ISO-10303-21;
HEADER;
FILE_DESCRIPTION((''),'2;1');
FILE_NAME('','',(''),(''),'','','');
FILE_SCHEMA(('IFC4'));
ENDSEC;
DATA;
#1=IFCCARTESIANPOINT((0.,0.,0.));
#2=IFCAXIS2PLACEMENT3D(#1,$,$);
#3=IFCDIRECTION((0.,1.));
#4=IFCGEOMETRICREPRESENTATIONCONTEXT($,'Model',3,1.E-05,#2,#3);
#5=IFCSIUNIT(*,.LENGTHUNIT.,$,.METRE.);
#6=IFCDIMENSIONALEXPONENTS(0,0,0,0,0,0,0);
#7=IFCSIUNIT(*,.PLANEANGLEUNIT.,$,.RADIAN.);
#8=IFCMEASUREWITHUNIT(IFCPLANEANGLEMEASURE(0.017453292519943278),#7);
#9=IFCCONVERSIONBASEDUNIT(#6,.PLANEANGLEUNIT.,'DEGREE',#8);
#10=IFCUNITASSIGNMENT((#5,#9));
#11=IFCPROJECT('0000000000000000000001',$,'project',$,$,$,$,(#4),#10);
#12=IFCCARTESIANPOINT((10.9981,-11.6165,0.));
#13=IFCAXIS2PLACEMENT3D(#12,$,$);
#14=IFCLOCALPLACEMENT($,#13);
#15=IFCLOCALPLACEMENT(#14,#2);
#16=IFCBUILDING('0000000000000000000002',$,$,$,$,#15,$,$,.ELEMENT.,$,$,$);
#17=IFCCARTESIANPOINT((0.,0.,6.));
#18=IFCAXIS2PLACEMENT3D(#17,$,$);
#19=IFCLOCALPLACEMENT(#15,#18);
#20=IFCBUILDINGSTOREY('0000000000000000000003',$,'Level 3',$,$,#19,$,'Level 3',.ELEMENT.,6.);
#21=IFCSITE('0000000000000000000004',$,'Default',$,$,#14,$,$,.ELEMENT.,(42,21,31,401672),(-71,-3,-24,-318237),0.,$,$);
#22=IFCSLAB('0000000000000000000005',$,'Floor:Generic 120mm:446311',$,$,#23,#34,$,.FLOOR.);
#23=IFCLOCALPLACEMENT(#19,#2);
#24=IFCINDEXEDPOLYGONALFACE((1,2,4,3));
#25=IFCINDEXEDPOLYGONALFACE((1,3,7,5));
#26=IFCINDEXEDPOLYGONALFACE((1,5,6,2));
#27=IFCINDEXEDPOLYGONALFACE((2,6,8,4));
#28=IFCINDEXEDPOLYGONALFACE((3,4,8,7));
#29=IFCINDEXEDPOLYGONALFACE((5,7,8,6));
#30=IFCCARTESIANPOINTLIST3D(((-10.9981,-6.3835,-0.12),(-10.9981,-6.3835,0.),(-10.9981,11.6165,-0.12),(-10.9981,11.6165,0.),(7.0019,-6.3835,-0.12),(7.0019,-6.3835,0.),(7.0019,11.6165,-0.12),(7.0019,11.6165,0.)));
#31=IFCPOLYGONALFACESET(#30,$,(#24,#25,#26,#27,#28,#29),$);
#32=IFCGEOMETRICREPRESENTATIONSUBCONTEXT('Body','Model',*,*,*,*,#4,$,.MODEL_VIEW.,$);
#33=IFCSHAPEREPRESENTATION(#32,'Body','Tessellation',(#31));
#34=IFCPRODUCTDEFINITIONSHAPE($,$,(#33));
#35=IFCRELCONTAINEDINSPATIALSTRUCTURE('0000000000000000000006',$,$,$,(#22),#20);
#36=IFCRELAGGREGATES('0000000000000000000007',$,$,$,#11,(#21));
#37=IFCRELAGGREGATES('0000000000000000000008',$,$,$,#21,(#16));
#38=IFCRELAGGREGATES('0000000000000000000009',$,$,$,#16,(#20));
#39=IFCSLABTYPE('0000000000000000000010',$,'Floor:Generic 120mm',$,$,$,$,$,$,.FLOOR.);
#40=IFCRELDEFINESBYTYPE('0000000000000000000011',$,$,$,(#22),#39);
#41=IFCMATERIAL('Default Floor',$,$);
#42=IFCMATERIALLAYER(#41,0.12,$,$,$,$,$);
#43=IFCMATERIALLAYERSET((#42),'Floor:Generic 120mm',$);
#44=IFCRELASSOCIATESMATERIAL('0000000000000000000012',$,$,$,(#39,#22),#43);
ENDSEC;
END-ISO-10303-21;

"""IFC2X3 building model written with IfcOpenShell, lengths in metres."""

from ifc_helpers import new_model, entity, si_unit, converted_unit, direction, frame, origin, origin_2d_with_axis, place, context, subcontext, project, spatial, rectangle, extrude, material, layer, layer_set, layer_usage, type_object, element, save


model = new_model("IFC2X3")

# Units and contexts
model_context = context("Model", 3, precision=1e-05, world=origin(), true_north=direction((0.0, 1.0)))
body_context = subcontext(model_context, "Body", "Model", "MODEL_VIEW")
ifc_project = project(units=[si_unit("LENGTHUNIT", "METRE"), converted_unit("PLANEANGLEUNIT", "DEGREE", entity("IfcPlaneAngleMeasure", 0.017453292519943278), si_unit("PLANEANGLEUNIT", "RADIAN"), dimensions=[0, 0, 0, 0, 0, 0, 0])], contexts=[model_context])

# Site, building, storey
site_placement = place(None, frame((10.9981, -11.6165, 0.0)))
site = spatial("IfcSite", under=ifc_project, at=site_placement, Name="Default", CompositionType="ELEMENT", RefLatitude=(42, 21, 31, 401672), RefLongitude=(-71, -3, -24, -318237), RefElevation=0.0)
building_placement = place(site_placement, origin())
building = spatial("IfcBuilding", under=site, at=building_placement, CompositionType="ELEMENT")
storey_placement = place(building_placement, frame((0.0, 0.0, 6.0)))
storey = spatial("IfcBuildingStorey", under=building, at=storey_placement, Name="Level 3", LongName="Level 3", CompositionType="ELEMENT", Elevation=6.0)

# Slab
ifc_material_1 = material(Name="Default Floor")
ifc_layer = layer(ifc_material_1, 0.12)
ifc_layer_set = layer_set([ifc_layer], Name="Floor:Generic 120mm")
ifc_layer_usage = layer_usage(ifc_layer_set, "AXIS3", "POSITIVE", 0.0)
slab_type = type_object("IfcSlabType", Name="Floor:Generic 120mm", PredefinedType="FLOOR", material=ifc_layer_set)
slab_placement = place(storey_placement, origin())
element("IfcSlab", 1, at=slab_placement, inside=storey, type_object=slab_type, material=ifc_layer_usage, Name="Floor:Generic 120mm:446311", PredefinedType="FLOOR", context=body_context, shape_type="SweptSolid", body=[
    extrude(rectangle(XDim=18.0, YDim=18.0, at=origin_2d_with_axis()), frame((-1.9981, 2.6165, 0.0), z_axis=(0.0, 0.0, -1.0), x_axis=(0.0, 1.0, 0.0)), (0.0, 0.0, 1.0), 0.12),
])

save(model, "model.ifc")
